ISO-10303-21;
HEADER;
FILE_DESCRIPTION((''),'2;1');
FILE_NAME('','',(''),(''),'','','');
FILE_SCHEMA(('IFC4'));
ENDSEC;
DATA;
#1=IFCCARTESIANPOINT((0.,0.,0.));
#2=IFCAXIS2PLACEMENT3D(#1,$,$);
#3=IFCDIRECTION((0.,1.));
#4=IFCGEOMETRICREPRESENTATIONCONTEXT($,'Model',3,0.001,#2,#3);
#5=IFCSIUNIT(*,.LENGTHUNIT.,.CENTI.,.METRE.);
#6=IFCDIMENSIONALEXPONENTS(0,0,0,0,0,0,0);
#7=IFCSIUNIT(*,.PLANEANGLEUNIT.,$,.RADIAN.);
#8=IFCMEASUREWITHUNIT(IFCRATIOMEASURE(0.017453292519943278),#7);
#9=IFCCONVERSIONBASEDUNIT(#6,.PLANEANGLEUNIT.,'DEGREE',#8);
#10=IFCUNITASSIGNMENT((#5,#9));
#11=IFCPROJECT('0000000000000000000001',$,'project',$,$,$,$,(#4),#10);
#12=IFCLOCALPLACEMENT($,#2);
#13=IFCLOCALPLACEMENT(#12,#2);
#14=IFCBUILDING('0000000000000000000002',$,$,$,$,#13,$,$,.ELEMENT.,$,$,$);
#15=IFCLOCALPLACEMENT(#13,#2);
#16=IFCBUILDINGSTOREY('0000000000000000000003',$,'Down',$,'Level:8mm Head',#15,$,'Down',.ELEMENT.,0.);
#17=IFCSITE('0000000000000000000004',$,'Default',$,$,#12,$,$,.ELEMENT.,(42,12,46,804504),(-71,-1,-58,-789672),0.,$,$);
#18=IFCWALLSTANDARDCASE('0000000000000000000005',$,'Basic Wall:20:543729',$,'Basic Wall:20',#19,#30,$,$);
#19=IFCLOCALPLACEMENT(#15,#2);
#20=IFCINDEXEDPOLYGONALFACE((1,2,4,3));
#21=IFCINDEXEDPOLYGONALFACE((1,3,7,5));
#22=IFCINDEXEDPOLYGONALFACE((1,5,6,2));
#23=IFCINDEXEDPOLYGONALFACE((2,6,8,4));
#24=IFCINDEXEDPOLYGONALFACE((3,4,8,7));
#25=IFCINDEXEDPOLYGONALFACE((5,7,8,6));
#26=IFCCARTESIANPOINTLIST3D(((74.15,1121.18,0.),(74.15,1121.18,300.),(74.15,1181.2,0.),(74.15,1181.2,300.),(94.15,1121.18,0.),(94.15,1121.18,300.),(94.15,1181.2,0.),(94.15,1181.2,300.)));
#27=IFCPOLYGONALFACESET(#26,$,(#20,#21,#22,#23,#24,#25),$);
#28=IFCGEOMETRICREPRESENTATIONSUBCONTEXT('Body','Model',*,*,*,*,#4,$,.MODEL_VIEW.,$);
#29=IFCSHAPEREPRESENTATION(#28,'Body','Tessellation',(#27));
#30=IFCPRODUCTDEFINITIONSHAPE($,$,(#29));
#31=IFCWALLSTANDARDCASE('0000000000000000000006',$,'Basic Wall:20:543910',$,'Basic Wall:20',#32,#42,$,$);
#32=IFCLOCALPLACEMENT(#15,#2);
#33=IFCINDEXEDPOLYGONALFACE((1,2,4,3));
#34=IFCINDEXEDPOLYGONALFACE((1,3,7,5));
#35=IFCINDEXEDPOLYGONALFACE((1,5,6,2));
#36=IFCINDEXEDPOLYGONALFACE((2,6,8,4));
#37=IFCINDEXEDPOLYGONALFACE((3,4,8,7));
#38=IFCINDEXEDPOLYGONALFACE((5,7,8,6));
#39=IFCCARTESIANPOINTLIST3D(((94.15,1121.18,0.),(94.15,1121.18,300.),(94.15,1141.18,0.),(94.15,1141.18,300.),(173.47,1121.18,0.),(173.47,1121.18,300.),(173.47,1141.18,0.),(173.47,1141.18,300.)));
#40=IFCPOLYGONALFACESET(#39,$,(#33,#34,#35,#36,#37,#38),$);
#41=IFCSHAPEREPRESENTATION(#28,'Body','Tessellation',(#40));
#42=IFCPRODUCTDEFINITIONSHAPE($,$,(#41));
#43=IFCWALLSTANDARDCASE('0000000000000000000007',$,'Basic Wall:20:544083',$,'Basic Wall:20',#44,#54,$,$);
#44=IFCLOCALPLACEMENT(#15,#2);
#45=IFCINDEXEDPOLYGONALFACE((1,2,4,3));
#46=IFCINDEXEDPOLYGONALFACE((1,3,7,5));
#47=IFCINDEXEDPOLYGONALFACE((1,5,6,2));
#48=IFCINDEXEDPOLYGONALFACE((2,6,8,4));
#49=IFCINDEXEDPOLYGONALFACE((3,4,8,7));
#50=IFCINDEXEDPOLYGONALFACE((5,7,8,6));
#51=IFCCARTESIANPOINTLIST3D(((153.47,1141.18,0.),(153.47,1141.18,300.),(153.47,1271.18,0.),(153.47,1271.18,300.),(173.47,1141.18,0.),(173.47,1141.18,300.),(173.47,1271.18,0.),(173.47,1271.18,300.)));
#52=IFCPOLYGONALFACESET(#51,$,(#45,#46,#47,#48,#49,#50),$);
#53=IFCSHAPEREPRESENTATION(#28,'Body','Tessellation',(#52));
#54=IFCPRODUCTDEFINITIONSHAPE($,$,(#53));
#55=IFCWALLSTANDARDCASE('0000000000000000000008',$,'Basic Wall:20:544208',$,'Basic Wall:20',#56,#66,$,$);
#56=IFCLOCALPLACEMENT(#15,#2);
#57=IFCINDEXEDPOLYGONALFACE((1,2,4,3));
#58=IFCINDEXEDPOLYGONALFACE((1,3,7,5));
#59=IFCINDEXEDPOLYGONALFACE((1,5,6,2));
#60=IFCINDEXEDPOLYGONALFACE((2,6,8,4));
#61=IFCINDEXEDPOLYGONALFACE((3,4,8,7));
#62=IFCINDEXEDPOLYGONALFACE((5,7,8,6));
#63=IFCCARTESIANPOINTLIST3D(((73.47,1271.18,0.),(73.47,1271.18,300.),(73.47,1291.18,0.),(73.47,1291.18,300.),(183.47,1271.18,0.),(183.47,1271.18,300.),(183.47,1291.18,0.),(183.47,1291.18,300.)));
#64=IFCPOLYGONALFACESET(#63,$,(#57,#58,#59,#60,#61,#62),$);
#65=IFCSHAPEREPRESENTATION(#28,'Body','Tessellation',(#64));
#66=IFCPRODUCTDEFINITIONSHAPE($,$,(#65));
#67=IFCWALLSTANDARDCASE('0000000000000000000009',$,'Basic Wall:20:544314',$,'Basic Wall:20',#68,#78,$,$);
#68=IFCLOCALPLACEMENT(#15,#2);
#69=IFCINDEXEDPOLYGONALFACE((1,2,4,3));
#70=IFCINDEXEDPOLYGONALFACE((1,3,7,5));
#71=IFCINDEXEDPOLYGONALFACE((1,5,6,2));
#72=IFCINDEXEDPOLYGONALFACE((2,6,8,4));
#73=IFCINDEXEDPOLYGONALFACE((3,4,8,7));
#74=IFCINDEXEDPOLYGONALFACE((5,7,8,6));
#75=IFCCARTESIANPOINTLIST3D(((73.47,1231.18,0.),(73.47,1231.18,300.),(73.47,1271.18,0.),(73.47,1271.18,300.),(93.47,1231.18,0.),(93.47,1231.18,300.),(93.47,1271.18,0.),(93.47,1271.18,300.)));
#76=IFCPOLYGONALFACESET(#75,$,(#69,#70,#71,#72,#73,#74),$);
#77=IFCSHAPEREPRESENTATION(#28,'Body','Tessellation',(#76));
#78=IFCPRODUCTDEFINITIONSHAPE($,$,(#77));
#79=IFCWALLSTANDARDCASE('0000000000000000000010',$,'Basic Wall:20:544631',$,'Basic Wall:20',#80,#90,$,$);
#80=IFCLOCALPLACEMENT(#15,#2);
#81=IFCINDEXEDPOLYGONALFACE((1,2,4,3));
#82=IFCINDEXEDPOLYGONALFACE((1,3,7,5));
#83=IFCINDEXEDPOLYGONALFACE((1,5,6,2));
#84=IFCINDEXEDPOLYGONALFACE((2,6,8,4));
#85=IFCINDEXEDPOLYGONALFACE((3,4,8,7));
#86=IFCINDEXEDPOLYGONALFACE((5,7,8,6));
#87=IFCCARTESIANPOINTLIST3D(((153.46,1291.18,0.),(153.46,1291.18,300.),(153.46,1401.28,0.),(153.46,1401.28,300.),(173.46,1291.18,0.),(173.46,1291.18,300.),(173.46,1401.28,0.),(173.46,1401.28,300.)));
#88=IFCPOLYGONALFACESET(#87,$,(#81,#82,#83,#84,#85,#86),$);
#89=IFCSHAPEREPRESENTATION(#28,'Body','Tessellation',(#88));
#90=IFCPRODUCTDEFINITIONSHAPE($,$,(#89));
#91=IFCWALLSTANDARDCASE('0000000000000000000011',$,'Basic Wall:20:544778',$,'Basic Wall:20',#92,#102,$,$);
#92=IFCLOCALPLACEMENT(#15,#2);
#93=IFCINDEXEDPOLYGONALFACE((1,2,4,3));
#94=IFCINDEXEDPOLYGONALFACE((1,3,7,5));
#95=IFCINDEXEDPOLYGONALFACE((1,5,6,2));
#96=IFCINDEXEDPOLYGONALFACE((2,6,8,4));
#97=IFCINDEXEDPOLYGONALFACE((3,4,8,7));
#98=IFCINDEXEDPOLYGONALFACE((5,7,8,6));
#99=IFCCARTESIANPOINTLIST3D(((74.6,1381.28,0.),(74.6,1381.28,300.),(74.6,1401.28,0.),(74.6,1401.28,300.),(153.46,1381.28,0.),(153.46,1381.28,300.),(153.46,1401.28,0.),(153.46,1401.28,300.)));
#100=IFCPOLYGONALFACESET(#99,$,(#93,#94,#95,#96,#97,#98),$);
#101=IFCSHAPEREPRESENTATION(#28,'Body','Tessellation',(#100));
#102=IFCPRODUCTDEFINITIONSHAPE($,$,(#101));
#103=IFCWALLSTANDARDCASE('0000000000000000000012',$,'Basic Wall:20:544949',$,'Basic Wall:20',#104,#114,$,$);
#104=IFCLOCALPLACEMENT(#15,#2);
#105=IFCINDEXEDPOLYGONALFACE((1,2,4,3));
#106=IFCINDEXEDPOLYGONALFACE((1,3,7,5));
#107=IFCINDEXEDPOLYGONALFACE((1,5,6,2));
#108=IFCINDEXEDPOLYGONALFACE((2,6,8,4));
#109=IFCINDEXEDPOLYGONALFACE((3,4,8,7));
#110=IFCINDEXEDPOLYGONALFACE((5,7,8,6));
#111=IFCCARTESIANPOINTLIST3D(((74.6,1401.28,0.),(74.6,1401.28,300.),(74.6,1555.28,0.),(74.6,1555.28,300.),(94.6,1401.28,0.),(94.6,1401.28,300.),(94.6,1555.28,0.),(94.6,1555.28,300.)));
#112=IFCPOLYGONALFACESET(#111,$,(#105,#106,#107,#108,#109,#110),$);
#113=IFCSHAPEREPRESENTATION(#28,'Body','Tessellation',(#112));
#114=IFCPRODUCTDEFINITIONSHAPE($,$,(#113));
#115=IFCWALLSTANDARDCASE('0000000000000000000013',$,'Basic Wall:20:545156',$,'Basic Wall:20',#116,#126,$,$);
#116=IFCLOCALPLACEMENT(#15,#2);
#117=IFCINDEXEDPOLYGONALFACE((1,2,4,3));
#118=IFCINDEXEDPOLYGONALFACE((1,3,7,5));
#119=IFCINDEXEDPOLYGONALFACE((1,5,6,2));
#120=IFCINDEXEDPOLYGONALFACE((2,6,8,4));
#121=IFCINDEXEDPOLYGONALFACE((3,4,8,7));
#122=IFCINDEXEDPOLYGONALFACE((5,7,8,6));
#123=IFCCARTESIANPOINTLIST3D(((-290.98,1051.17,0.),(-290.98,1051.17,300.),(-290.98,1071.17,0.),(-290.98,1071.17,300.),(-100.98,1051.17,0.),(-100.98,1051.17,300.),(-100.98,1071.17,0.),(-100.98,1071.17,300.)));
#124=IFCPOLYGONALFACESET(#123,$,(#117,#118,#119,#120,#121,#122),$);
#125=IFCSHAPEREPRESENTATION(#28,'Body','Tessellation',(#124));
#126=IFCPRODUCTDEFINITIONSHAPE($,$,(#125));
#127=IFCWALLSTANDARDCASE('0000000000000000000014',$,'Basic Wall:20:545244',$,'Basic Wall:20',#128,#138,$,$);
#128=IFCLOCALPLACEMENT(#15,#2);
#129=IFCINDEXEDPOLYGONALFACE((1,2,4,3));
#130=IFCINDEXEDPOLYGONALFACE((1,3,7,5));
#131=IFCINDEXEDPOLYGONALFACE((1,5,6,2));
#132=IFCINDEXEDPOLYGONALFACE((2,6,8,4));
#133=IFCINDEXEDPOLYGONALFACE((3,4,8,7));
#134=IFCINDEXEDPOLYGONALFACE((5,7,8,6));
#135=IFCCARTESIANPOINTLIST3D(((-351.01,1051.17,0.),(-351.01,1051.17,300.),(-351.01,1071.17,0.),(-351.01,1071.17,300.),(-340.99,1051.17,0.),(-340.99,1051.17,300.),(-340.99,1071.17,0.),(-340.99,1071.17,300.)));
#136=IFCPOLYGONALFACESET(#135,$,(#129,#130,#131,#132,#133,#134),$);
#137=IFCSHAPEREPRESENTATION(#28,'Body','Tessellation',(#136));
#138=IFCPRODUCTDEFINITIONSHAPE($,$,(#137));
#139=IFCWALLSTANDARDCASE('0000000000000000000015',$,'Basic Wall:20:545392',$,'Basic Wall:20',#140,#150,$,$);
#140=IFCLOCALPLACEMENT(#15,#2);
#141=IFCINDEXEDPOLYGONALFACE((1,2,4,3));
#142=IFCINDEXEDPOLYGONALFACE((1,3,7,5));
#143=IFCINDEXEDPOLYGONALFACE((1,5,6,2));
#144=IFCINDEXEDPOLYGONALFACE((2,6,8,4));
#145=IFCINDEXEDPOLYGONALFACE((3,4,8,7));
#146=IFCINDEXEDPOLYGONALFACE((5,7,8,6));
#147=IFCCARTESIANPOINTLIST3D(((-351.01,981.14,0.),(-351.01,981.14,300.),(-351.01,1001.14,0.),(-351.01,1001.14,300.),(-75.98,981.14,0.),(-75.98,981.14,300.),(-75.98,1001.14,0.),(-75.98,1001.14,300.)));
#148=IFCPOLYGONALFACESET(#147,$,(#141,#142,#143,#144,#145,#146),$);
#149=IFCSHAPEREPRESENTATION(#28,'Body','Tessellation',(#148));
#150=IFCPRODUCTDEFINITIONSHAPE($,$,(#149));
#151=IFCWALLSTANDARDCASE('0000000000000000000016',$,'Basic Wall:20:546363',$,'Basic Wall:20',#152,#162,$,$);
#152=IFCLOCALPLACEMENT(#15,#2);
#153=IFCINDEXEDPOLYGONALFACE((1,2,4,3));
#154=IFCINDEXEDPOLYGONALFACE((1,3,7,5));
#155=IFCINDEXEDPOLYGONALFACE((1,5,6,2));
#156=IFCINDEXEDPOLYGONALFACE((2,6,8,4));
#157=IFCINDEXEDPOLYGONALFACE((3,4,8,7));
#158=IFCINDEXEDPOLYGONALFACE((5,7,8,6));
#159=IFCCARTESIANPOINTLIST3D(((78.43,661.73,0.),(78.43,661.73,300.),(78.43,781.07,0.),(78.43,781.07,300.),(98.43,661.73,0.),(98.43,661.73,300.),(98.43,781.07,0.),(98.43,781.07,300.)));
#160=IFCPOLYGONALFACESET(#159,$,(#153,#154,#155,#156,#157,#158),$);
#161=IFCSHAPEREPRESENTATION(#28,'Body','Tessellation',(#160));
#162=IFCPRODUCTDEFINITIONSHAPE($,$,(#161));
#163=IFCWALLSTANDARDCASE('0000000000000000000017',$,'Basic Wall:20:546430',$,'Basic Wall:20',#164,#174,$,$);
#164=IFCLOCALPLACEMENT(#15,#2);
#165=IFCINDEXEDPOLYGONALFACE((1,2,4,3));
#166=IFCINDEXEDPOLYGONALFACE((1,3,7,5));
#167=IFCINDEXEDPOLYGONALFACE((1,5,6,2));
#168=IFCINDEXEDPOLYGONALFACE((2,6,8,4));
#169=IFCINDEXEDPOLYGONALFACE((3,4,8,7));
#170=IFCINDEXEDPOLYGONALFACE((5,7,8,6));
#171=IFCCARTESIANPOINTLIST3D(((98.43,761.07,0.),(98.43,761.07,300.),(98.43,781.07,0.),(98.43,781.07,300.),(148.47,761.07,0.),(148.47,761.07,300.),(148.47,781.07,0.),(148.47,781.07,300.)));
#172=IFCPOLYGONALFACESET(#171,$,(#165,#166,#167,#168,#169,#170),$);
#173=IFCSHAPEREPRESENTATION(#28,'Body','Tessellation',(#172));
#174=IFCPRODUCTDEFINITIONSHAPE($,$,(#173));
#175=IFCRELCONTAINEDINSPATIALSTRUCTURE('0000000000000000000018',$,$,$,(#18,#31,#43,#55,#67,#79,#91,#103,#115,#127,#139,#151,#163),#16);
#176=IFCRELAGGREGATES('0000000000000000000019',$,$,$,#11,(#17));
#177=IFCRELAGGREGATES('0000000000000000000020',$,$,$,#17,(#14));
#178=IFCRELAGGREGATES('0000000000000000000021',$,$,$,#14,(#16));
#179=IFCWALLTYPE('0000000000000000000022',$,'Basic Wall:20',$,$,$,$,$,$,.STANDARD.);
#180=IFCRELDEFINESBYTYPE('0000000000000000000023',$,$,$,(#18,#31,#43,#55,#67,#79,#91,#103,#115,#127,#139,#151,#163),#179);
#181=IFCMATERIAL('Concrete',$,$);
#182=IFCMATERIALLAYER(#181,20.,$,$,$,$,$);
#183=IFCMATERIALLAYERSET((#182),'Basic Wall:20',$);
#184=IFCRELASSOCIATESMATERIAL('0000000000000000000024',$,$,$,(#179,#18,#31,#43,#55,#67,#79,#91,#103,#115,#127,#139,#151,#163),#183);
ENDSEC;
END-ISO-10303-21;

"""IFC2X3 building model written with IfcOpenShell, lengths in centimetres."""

from ifc_helpers import new_model, entity, si_unit, converted_unit, direction, frame, frame_2d, origin, place, context, subcontext, project, spatial, rectangle, extrude, material, layer, layer_set, layer_usage, type_object, element, save


model = new_model("IFC2X3")

# Units and contexts
model_context = context("Model", 3, precision=0.001, world=origin(), true_north=direction((0.0, 1.0)))
body_context = subcontext(model_context, "Body", "Model", "MODEL_VIEW")
ifc_project = project(units=[si_unit("LENGTHUNIT", "METRE", prefix="CENTI"), converted_unit("PLANEANGLEUNIT", "DEGREE", entity("IfcRatioMeasure", 0.017453292519943278), si_unit("PLANEANGLEUNIT", "RADIAN"), dimensions=[0, 0, 0, 0, 0, 0, 0])], contexts=[model_context])

# Site, building, storey
site_placement = place(None, origin())
site = spatial("IfcSite", under=ifc_project, at=site_placement, Name="Default", CompositionType="ELEMENT", RefLatitude=(42, 12, 46, 804504), RefLongitude=(-71, -1, -58, -789672), RefElevation=0.0)
building_placement = place(site_placement, origin())
building = spatial("IfcBuilding", under=site, at=building_placement, CompositionType="ELEMENT")
storey_placement = place(building_placement, origin())
storey = spatial("IfcBuildingStorey", under=building, at=storey_placement, Name="Down", ObjectType="Level:8mm Head", LongName="Down", CompositionType="ELEMENT", Elevation=0.0)

# Walls
ifc_material = material(Name="Concrete")
ifc_layer_1 = layer(ifc_material, 20.0)
ifc_layer_set_1 = layer_set([ifc_layer_1], Name="Basic Wall:20")
wall_type_1 = type_object("IfcWallType", Name="Basic Wall:20", PredefinedType="STANDARD", material=ifc_layer_set_1)
ifc_layer_usage_1 = layer_usage(ifc_layer_set_1, "AXIS2", "POSITIVE", -10.0)
wall_1_placement = place(storey_placement, frame((84.15, 1181.2, 0.0), z_axis=(0.0, 0.0, 1.0), x_axis=(0.0, -1.0, 0.0)))
element("IfcWallStandardCase", 1, at=wall_1_placement, inside=storey, type_object=wall_type_1, material=ifc_layer_usage_1, Name="Basic Wall:20:543729", ObjectType="Basic Wall:20", context=body_context, shape_type="SweptSolid", body=[
    extrude(rectangle(XDim=60.02, YDim=20.0, at=frame_2d((30.01, 0.0), x_axis=(-1.0, 0.0))), origin(), (0.0, 0.0, 1.0), 300.0),
])
ifc_layer_usage_2 = layer_usage(ifc_layer_set_1, "AXIS2", "POSITIVE", -10.0)
wall_2_placement = place(storey_placement, frame((94.15, 1131.18, 0.0)))
element("IfcWallStandardCase", 2, at=wall_2_placement, inside=storey, type_object=wall_type_1, material=ifc_layer_usage_2, Name="Basic Wall:20:543910", ObjectType="Basic Wall:20", context=body_context, shape_type="SweptSolid", body=[
    extrude(rectangle(XDim=79.32, YDim=20.0, at=frame_2d((39.66, 0.0), x_axis=(-1.0, 0.0))), origin(), (0.0, 0.0, 1.0), 300.0),
])
ifc_layer_usage_3 = layer_usage(ifc_layer_set_1, "AXIS2", "POSITIVE", -10.0)
wall_3_placement = place(storey_placement, frame((163.47, 1141.18, 0.0), z_axis=(0.0, 0.0, 1.0), x_axis=(0.0, 1.0, 0.0)))
element("IfcWallStandardCase", 3, at=wall_3_placement, inside=storey, type_object=wall_type_1, material=ifc_layer_usage_3, Name="Basic Wall:20:544083", ObjectType="Basic Wall:20", context=body_context, shape_type="SweptSolid", body=[
    extrude(rectangle(XDim=130.0, YDim=20.0, at=frame_2d((65.0, 0.0), x_axis=(-1.0, 0.0))), origin(), (0.0, 0.0, 1.0), 300.0),
])
ifc_layer_usage_4 = layer_usage(ifc_layer_set_1, "AXIS2", "POSITIVE", -10.0)
wall_4_placement = place(storey_placement, frame((183.47, 1281.18, 0.0), z_axis=(0.0, 0.0, 1.0), x_axis=(-1.0, 0.0, 0.0)))
element("IfcWallStandardCase", 4, at=wall_4_placement, inside=storey, type_object=wall_type_1, material=ifc_layer_usage_4, Name="Basic Wall:20:544208", ObjectType="Basic Wall:20", context=body_context, shape_type="SweptSolid", body=[
    extrude(rectangle(XDim=110.0, YDim=20.0, at=frame_2d((55.0, 0.0), x_axis=(-1.0, 0.0))), origin(), (0.0, 0.0, 1.0), 300.0),
])
ifc_layer_usage_5 = layer_usage(ifc_layer_set_1, "AXIS2", "POSITIVE", -10.0)
wall_5_placement = place(storey_placement, frame((83.47, 1271.18, 0.0), z_axis=(0.0, 0.0, 1.0), x_axis=(0.0, -1.0, 0.0)))
element("IfcWallStandardCase", 5, at=wall_5_placement, inside=storey, type_object=wall_type_1, material=ifc_layer_usage_5, Name="Basic Wall:20:544314", ObjectType="Basic Wall:20", context=body_context, shape_type="SweptSolid", body=[
    extrude(rectangle(XDim=40.0, YDim=20.0, at=frame_2d((20.0, 0.0), x_axis=(-1.0, 0.0))), origin(), (0.0, 0.0, 1.0), 300.0),
])
ifc_layer_usage_6 = layer_usage(ifc_layer_set_1, "AXIS2", "NEGATIVE", 10.0)
wall_6_placement = place(storey_placement, frame((163.46, 1291.18, 0.0), z_axis=(0.0, 0.0, 1.0), x_axis=(0.0, 1.0, 0.0)))
element("IfcWallStandardCase", 6, at=wall_6_placement, inside=storey, type_object=wall_type_1, material=ifc_layer_usage_6, Name="Basic Wall:20:544631", ObjectType="Basic Wall:20", context=body_context, shape_type="SweptSolid", body=[
    extrude(rectangle(XDim=110.09, YDim=20.0, at=frame_2d((55.05, 0.0), x_axis=(-1.0, 0.0))), origin(), (0.0, 0.0, 1.0), 300.0),
])
ifc_layer_usage_7 = layer_usage(ifc_layer_set_1, "AXIS2", "POSITIVE", -10.0)
wall_7_placement = place(storey_placement, frame((153.46, 1391.28, 0.0), z_axis=(0.0, 0.0, 1.0), x_axis=(-1.0, 0.0, 0.0)))
element("IfcWallStandardCase", 7, at=wall_7_placement, inside=storey, type_object=wall_type_1, material=ifc_layer_usage_7, Name="Basic Wall:20:544778", ObjectType="Basic Wall:20", context=body_context, shape_type="SweptSolid", body=[
    extrude(rectangle(XDim=78.86, YDim=20.0, at=frame_2d((39.43, 0.0), x_axis=(-1.0, 0.0))), origin(), (0.0, 0.0, 1.0), 300.0),
])
ifc_layer_usage_8 = layer_usage(ifc_layer_set_1, "AXIS2", "NEGATIVE", 10.0)
wall_8_placement = place(storey_placement, frame((84.6, 1401.28, 0.0), z_axis=(0.0, 0.0, 1.0), x_axis=(0.0, 1.0, 0.0)))
element("IfcWallStandardCase", 8, at=wall_8_placement, inside=storey, type_object=wall_type_1, material=ifc_layer_usage_8, Name="Basic Wall:20:544949", ObjectType="Basic Wall:20", context=body_context, shape_type="SweptSolid", body=[
    extrude(rectangle(XDim=154.0, YDim=20.0, at=frame_2d((77.0, 0.0), x_axis=(-1.0, 0.0))), origin(), (0.0, 0.0, 1.0), 300.0),
])
ifc_layer_usage_9 = layer_usage(ifc_layer_set_1, "AXIS2", "NEGATIVE", 10.0)
wall_9_placement = place(storey_placement, frame((-290.98, 1061.17, 0.0)))
element("IfcWallStandardCase", 9, at=wall_9_placement, inside=storey, type_object=wall_type_1, material=ifc_layer_usage_9, Name="Basic Wall:20:545156", ObjectType="Basic Wall:20", context=body_context, shape_type="SweptSolid", body=[
    extrude(rectangle(XDim=190.0, YDim=20.0, at=frame_2d((95.0, 0.0), x_axis=(-1.0, 0.0))), origin(), (0.0, 0.0, 1.0), 300.0),
])
ifc_layer_usage_10 = layer_usage(ifc_layer_set_1, "AXIS2", "POSITIVE", -10.0)
wall_10_placement = place(storey_placement, frame((-340.99, 1061.17, 0.0), z_axis=(0.0, 0.0, 1.0), x_axis=(-1.0, 0.0, 0.0)))
element("IfcWallStandardCase", 10, at=wall_10_placement, inside=storey, type_object=wall_type_1, material=ifc_layer_usage_10, Name="Basic Wall:20:545244", ObjectType="Basic Wall:20", context=body_context, shape_type="SweptSolid", body=[
    extrude(rectangle(XDim=10.01, YDim=20.0, at=frame_2d((5.01, 0.0), x_axis=(-1.0, 0.0))), origin(), (0.0, 0.0, 1.0), 300.0),
])
ifc_layer_usage_11 = layer_usage(ifc_layer_set_1, "AXIS2", "POSITIVE", -10.0)
wall_11_placement = place(storey_placement, frame((-75.98, 991.14, 0.0), z_axis=(0.0, 0.0, 1.0), x_axis=(-1.0, 0.0, 0.0)))
element("IfcWallStandardCase", 11, at=wall_11_placement, inside=storey, type_object=wall_type_1, material=ifc_layer_usage_11, Name="Basic Wall:20:545392", ObjectType="Basic Wall:20", context=body_context, shape_type="SweptSolid", body=[
    extrude(rectangle(XDim=275.03, YDim=20.0, at=frame_2d((137.51, 0.0), x_axis=(-1.0, 0.0))), origin(), (0.0, 0.0, 1.0), 300.0),
])
ifc_layer_usage_12 = layer_usage(ifc_layer_set_1, "AXIS2", "NEGATIVE", 10.0)
wall_12_placement = place(storey_placement, frame((88.43, 661.73, 0.0), z_axis=(0.0, 0.0, 1.0), x_axis=(0.0, 1.0, 0.0)))
element("IfcWallStandardCase", 12, at=wall_12_placement, inside=storey, type_object=wall_type_1, material=ifc_layer_usage_12, Name="Basic Wall:20:546363", ObjectType="Basic Wall:20", context=body_context, shape_type="SweptSolid", body=[
    extrude(rectangle(XDim=119.33, YDim=20.0, at=frame_2d((59.67, 0.0), x_axis=(-1.0, 0.0))), origin(), (0.0, 0.0, 1.0), 300.0),
])
ifc_layer_usage_13 = layer_usage(ifc_layer_set_1, "AXIS2", "NEGATIVE", 10.0)
wall_13_placement = place(storey_placement, frame((98.43, 771.07, 0.0)))
element("IfcWallStandardCase", 13, at=wall_13_placement, inside=storey, type_object=wall_type_1, material=ifc_layer_usage_13, Name="Basic Wall:20:546430", ObjectType="Basic Wall:20", context=body_context, shape_type="SweptSolid", body=[
    extrude(rectangle(XDim=50.03, YDim=20.0, at=frame_2d((25.02, 0.0), x_axis=(-1.0, 0.0))), origin(), (0.0, 0.0, 1.0), 300.0),
])

save(model, "model.ifc")
